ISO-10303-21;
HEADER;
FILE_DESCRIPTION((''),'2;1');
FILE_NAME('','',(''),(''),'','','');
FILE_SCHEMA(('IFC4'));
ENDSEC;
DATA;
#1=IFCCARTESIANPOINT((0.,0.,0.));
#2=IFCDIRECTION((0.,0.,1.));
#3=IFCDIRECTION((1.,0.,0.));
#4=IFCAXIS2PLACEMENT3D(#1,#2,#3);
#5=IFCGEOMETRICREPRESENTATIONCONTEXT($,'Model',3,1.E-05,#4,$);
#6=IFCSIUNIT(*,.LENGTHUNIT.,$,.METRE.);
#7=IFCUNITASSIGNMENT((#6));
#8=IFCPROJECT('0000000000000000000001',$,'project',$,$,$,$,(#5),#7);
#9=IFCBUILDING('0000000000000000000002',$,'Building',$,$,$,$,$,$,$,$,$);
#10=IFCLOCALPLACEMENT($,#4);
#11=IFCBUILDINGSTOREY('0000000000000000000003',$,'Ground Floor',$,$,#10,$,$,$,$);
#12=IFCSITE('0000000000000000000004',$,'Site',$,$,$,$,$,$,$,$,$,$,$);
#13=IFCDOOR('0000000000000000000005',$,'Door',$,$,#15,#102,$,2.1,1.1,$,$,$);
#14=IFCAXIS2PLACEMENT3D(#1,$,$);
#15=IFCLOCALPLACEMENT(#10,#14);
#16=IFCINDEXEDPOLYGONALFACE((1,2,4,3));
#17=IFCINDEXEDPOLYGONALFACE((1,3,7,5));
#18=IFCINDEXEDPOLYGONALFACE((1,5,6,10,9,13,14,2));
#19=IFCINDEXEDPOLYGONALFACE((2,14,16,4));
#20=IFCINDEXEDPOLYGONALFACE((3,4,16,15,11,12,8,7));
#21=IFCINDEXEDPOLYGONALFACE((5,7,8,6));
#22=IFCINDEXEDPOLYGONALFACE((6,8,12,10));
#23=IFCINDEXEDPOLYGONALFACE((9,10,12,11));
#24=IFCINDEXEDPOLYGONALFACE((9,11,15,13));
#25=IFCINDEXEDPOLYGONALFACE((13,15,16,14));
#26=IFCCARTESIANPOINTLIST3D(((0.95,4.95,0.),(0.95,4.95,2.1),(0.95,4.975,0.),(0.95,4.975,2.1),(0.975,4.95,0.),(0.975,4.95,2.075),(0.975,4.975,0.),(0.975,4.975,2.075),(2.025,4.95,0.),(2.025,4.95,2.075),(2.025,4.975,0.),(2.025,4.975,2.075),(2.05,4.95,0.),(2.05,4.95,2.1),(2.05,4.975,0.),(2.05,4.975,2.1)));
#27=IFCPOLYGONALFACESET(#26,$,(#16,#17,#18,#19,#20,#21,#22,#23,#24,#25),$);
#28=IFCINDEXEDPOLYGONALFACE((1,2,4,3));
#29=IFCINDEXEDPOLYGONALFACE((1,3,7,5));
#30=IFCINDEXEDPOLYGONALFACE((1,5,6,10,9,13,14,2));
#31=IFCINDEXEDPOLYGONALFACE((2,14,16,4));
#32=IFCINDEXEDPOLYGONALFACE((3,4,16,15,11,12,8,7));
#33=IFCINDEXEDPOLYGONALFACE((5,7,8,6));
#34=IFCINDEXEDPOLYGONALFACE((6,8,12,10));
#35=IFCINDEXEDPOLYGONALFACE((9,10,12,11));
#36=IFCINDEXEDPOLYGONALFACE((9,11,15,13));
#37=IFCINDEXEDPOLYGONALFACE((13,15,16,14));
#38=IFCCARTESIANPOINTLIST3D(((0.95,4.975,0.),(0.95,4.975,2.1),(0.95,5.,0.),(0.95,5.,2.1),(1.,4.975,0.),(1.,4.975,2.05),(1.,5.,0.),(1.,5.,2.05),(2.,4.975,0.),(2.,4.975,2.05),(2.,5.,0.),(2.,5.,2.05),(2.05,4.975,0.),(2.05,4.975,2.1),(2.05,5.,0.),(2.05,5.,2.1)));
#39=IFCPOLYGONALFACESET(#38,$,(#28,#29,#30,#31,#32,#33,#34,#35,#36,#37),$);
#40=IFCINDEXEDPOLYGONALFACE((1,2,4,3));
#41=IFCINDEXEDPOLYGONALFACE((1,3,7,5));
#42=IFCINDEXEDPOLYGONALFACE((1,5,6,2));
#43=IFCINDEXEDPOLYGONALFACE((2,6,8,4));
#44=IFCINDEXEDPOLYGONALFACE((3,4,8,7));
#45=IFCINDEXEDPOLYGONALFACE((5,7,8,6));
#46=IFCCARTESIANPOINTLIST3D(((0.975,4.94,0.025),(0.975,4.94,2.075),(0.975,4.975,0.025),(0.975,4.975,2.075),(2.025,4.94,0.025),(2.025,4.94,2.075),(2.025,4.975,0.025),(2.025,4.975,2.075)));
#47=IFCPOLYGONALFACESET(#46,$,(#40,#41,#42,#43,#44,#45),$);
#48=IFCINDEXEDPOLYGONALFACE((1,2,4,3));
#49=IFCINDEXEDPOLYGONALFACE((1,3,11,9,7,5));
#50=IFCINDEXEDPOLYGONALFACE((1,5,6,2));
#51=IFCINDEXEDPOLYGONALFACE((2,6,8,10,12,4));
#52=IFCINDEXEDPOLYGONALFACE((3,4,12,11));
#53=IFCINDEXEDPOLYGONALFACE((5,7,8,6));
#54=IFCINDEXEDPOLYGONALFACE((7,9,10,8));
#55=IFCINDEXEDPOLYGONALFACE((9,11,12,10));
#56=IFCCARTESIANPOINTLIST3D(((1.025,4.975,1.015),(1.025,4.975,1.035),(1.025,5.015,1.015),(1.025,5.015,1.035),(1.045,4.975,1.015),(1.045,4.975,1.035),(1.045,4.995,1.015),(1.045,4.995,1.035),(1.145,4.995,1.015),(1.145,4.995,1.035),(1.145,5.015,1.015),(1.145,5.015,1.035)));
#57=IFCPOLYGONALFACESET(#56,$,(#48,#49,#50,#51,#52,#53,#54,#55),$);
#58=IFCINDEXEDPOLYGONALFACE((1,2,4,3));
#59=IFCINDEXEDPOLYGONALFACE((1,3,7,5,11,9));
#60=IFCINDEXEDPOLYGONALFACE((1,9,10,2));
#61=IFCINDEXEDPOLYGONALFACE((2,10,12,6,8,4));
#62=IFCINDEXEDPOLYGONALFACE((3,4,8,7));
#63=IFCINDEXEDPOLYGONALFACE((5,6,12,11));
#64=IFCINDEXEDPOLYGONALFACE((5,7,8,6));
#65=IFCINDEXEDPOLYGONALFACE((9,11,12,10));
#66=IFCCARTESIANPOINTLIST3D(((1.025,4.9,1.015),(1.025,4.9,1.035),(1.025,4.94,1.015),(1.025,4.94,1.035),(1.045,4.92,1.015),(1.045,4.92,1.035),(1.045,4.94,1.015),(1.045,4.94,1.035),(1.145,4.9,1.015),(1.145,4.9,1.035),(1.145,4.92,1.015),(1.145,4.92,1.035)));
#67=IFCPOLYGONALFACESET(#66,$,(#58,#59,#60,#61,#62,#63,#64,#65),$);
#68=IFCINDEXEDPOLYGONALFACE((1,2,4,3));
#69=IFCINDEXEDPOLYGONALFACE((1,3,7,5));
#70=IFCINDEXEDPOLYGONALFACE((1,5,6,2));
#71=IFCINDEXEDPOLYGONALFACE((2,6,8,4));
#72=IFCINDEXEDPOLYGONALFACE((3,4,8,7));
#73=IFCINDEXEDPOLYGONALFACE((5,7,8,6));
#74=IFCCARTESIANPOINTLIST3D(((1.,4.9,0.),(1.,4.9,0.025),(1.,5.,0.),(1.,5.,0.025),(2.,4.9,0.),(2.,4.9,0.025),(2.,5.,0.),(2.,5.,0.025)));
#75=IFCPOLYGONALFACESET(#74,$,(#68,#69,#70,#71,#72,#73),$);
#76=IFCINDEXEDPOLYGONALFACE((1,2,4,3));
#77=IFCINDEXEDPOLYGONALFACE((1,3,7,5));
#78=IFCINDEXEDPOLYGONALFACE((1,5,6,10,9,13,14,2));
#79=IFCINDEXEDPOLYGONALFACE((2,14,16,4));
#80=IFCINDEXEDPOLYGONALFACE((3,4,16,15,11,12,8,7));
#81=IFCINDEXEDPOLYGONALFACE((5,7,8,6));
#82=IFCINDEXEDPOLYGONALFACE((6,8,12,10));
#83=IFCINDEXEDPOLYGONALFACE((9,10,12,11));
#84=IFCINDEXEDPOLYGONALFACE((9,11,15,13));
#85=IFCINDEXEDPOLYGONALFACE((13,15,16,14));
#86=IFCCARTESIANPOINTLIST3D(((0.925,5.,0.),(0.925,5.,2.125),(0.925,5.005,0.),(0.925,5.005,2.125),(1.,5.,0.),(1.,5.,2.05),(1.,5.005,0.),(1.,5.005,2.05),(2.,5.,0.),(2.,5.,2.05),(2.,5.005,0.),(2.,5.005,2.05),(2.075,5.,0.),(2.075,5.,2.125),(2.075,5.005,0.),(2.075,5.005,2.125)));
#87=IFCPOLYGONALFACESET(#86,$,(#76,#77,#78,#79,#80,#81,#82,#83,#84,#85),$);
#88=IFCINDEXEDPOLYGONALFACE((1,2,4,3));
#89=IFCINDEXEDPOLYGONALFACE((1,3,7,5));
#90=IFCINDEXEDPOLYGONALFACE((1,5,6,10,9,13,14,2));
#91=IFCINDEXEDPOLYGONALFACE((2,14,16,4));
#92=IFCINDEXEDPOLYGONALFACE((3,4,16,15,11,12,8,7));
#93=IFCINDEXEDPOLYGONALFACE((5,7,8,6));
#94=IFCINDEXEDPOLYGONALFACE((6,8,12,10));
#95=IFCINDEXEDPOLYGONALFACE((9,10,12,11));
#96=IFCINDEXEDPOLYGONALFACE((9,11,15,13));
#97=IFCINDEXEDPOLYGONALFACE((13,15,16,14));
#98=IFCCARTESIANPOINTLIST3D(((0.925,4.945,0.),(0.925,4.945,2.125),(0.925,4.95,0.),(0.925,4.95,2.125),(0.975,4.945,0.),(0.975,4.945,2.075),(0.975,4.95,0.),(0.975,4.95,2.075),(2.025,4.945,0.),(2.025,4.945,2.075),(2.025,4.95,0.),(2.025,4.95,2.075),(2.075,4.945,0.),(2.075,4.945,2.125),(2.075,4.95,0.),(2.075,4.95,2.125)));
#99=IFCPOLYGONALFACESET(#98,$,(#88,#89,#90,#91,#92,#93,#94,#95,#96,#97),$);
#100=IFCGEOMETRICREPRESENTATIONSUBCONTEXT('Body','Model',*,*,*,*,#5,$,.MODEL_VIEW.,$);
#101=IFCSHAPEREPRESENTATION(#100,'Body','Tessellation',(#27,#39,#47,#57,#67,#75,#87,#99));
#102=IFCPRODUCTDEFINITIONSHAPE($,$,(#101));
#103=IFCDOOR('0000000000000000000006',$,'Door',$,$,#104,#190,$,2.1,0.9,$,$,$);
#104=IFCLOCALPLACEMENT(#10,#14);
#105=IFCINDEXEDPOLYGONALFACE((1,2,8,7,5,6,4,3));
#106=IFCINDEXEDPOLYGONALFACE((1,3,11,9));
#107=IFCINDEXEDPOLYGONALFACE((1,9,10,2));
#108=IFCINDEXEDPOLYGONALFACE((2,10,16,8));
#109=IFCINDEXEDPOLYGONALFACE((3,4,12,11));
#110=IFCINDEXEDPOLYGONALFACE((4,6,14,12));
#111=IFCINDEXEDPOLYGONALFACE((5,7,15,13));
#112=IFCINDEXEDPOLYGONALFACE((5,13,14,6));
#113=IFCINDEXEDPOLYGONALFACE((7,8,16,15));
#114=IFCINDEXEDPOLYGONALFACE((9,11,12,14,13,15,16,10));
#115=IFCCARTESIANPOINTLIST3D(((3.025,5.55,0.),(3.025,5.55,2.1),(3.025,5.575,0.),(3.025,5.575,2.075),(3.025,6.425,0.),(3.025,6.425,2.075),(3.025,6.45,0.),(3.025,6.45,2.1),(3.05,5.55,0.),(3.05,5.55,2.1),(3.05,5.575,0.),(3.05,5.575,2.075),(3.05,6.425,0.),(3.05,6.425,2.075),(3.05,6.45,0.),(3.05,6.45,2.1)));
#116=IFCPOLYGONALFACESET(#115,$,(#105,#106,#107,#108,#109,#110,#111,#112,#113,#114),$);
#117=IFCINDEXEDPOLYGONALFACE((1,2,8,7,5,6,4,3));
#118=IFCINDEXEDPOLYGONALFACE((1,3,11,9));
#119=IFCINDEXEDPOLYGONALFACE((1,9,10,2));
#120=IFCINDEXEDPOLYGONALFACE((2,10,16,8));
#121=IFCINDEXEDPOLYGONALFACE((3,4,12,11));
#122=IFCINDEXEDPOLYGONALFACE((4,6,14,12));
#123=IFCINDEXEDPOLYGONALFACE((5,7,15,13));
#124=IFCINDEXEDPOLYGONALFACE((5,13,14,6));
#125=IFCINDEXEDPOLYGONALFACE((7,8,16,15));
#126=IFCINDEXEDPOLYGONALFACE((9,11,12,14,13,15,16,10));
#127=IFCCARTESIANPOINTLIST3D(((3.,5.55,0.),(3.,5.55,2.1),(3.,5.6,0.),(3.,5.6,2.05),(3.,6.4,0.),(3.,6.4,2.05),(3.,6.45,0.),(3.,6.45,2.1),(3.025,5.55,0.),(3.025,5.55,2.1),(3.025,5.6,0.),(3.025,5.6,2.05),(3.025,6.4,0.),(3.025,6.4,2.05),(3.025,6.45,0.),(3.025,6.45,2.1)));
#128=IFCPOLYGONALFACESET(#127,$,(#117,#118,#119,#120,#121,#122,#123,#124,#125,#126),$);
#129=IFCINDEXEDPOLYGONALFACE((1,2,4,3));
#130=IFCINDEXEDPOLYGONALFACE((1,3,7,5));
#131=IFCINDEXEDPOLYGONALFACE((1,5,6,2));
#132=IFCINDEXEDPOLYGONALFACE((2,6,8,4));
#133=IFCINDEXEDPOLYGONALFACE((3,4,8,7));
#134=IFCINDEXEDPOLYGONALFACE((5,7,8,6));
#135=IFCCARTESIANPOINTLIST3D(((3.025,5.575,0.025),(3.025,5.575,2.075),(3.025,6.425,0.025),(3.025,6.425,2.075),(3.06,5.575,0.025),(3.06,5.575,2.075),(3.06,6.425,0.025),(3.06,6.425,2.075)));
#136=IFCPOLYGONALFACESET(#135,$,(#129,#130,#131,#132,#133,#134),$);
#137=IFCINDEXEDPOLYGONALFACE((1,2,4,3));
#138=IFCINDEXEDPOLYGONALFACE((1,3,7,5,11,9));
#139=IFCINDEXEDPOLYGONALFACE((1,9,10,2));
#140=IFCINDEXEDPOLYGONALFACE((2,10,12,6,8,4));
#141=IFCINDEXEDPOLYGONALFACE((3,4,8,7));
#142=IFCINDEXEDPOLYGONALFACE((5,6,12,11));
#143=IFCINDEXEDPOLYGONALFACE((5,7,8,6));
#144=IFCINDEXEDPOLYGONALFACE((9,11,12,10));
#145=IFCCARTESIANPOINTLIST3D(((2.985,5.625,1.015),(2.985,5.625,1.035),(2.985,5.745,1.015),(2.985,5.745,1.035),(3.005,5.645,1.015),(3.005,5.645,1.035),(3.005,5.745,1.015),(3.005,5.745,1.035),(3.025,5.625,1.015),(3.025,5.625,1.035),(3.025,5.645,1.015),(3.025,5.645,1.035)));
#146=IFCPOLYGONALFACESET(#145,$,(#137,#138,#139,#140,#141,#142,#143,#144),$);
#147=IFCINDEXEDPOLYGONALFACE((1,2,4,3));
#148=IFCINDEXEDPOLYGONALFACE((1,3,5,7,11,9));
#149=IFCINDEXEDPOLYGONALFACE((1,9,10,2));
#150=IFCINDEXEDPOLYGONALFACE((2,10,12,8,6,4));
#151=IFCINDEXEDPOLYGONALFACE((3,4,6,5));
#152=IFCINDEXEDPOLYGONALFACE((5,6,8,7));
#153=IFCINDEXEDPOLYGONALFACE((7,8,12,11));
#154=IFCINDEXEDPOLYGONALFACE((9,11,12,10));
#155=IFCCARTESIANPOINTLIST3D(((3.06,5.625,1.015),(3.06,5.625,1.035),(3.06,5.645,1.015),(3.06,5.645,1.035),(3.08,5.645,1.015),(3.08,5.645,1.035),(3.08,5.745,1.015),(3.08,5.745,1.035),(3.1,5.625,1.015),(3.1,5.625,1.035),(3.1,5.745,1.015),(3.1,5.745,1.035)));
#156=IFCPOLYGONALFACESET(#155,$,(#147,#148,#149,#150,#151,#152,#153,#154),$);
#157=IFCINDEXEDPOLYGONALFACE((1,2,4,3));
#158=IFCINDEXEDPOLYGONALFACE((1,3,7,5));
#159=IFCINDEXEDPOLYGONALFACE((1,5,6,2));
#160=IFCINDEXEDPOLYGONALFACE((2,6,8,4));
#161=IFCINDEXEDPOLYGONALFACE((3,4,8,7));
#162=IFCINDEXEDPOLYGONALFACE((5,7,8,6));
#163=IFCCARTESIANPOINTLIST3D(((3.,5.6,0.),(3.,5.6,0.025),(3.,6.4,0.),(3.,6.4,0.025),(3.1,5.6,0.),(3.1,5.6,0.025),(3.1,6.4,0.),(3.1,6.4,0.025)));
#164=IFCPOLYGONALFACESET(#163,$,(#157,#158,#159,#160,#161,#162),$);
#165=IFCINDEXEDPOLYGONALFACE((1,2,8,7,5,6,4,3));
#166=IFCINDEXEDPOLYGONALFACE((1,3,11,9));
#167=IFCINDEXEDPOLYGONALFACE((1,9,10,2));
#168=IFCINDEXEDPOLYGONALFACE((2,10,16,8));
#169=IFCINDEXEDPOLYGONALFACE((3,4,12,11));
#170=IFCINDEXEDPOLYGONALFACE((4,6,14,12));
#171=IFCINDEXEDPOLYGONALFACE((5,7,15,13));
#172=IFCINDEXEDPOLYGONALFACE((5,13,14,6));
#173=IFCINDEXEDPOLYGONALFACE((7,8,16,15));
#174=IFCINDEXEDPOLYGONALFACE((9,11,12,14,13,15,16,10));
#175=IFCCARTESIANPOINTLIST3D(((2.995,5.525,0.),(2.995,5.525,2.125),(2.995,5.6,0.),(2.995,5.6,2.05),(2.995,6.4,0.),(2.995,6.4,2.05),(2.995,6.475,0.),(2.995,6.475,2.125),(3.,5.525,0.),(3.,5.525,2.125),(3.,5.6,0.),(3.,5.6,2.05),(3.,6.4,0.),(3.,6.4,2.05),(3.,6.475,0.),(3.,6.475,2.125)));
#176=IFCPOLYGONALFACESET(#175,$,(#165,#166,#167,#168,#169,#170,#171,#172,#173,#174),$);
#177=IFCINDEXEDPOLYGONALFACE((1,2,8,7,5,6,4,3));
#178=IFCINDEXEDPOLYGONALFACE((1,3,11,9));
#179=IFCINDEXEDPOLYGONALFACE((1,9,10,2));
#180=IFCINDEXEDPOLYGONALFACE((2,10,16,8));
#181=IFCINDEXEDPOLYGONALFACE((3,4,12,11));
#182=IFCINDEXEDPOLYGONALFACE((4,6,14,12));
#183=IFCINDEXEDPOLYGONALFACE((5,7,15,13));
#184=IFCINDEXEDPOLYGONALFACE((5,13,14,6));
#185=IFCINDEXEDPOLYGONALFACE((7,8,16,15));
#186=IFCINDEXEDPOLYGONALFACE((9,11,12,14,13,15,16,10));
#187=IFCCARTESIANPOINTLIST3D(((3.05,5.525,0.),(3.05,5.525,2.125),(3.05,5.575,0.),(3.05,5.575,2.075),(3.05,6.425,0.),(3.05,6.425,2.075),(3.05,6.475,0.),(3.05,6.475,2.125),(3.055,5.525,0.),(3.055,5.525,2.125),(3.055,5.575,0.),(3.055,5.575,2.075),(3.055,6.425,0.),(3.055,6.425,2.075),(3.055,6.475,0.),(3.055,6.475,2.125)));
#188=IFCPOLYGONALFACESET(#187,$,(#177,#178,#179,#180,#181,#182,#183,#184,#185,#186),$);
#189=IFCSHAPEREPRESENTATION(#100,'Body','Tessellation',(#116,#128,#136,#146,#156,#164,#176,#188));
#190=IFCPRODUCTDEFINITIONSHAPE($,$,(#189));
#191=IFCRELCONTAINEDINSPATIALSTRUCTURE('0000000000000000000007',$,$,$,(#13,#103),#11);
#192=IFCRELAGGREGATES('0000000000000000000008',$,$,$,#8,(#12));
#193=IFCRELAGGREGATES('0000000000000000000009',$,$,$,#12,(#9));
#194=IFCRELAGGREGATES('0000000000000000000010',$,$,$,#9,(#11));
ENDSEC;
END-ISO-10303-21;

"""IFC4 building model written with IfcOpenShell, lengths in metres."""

from ifc_helpers import new_model, si_unit, frame, origin_with_axes, place, context, subcontext, project, spatial, line, indexed_curve, outline, extrude, element, save


model = new_model("IFC4")

# Units and contexts
model_context = context("Model", 3, precision=1e-05, world=origin_with_axes())
body_context = subcontext(model_context, "Body", "Model", "MODEL_VIEW")
ifc_project = project(units=[si_unit("LENGTHUNIT", "METRE")], contexts=[model_context])

# Site, building, storey
site = spatial("IfcSite", under=ifc_project, Name="Site")
building = spatial("IfcBuilding", under=site, Name="Building")
storey_placement = place(None, origin_with_axes())
storey = spatial("IfcBuildingStorey", under=building, at=storey_placement, Name="Ground Floor")

# Doors
door_1_placement = place(storey_placement, frame((2.05, 5.0, 0.0), z_axis=(0.0, 0.0, 1.0), x_axis=(-1.0, 0.0, 0.0)))
element("IfcDoor", 1, at=door_1_placement, inside=storey, Name="Door", OverallHeight=2.1, OverallWidth=1.1, context=body_context, shape_type="SweptSolid", body=[
    extrude(outline(indexed_curve([(0.0, 0.0), (0.0, 2.1), (1.1, 2.1), (1.1, 0.0), (1.075, 0.0), (1.075, 2.075), (0.025, 2.075), (0.025, 0.0)], segments=[line(1, 2, 3, 4, 5, 6, 7, 8, 1)])), frame((0.0, 0.025, 0.0), z_axis=(0.0, -1.0, 0.0), x_axis=(1.0, 0.0, 0.0)), (0.0, 0.0, -1.0), 0.025),
    extrude(outline(indexed_curve([(0.0, 0.0), (0.0, 2.1), (1.1, 2.1), (1.1, 0.0), (1.05, 0.0), (1.05, 2.05), (0.05, 2.05), (0.05, 0.0)], segments=[line(1, 2, 3, 4, 5, 6, 7, 8, 1)])), frame((0.0, 0.0, 0.0), z_axis=(0.0, -1.0, 0.0), x_axis=(1.0, 0.0, 0.0)), (0.0, 0.0, -1.0), 0.025),
    extrude(outline(indexed_curve([(0.0, 0.0), (1.05, 0.0), (1.05, 0.035), (0.0, 0.035)], segments=[line(1, 2, 3, 4, 1)])), frame((0.025, 0.025, 0.025), z_axis=(0.0, 0.0, 1.0), x_axis=(1.0, 0.0, 0.0)), (0.0, 0.0, 1.0), 2.05),
    extrude(outline(indexed_curve([(0.0, 0.0), (0.0, -0.04), (-0.12, -0.04), (-0.12, -0.02), (-0.02, -0.02), (-0.02, 0.0)], segments=[line(1, 2, 3, 4, 5, 6, 1)])), frame((1.025, 0.025, 1.015), z_axis=(0.0, 0.0, 1.0), x_axis=(1.0, 0.0, 0.0)), (0.0, 0.0, 1.0), 0.02),
    extrude(outline(indexed_curve([(0.0, 0.0), (0.0, 0.04), (-0.12, 0.04), (-0.12, 0.02), (-0.02, 0.02), (-0.02, 0.0)], segments=[line(1, 2, 3, 4, 5, 6, 1)])), frame((1.025, 0.06, 1.015), z_axis=(0.0, 0.0, 1.0), x_axis=(1.0, 0.0, 0.0)), (0.0, 0.0, 1.0), 0.02),
    extrude(outline(indexed_curve([(0.0, 0.0), (1.0, 0.0), (1.0, 0.1), (0.0, 0.1)], segments=[line(1, 2, 3, 4, 1)])), frame((0.05, 0.0, 0.0), z_axis=(0.0, 0.0, 1.0), x_axis=(1.0, 0.0, 0.0)), (0.0, 0.0, 1.0), 0.025),
    extrude(outline(indexed_curve([(0.0, 0.0), (0.0, 2.125), (1.15, 2.125), (1.15, 0.0), (1.075, 0.0), (1.075, 2.05), (0.075, 2.05), (0.075, 0.0)], segments=[line(1, 2, 3, 4, 5, 6, 7, 8, 1)])), frame((-0.025, -0.005, 0.0), z_axis=(0.0, -1.0, 0.0), x_axis=(1.0, 0.0, 0.0)), (0.0, 0.0, -1.0), 0.005),
    extrude(outline(indexed_curve([(0.0, 0.0), (0.0, 2.125), (1.15, 2.125), (1.15, 0.0), (1.1, 0.0), (1.1, 2.075), (0.05, 2.075), (0.05, 0.0)], segments=[line(1, 2, 3, 4, 5, 6, 7, 8, 1)])), frame((-0.025, 0.05, 0.0), z_axis=(0.0, -1.0, 0.0), x_axis=(1.0, 0.0, 0.0)), (0.0, 0.0, -1.0), 0.005),
])
door_2_placement = place(storey_placement, frame((3.0, 6.45, 0.0), z_axis=(0.0, 0.0, 1.0), x_axis=(0.0, -1.0, 0.0)))
element("IfcDoor", 2, at=door_2_placement, inside=storey, Name="Door", OverallHeight=2.1, OverallWidth=0.9, context=body_context, shape_type="SweptSolid", body=[
    extrude(outline(indexed_curve([(0.0, 0.0), (0.0, 2.1), (0.9, 2.1), (0.9, 0.0), (0.875, 0.0), (0.875, 2.075), (0.025, 2.075), (0.025, 0.0)], segments=[line(1, 2, 3, 4, 5, 6, 7, 8, 1)])), frame((0.0, 0.025, 0.0), z_axis=(0.0, -1.0, 0.0), x_axis=(1.0, 0.0, 0.0)), (0.0, 0.0, -1.0), 0.025),
    extrude(outline(indexed_curve([(0.0, 0.0), (0.0, 2.1), (0.9, 2.1), (0.9, 0.0), (0.85, 0.0), (0.85, 2.05), (0.05, 2.05), (0.05, 0.0)], segments=[line(1, 2, 3, 4, 5, 6, 7, 8, 1)])), frame((0.0, 0.0, 0.0), z_axis=(0.0, -1.0, 0.0), x_axis=(1.0, 0.0, 0.0)), (0.0, 0.0, -1.0), 0.025),
    extrude(outline(indexed_curve([(0.0, 0.0), (0.85, 0.0), (0.85, 0.035), (0.0, 0.035)], segments=[line(1, 2, 3, 4, 1)])), frame((0.025, 0.025, 0.025), z_axis=(0.0, 0.0, 1.0), x_axis=(1.0, 0.0, 0.0)), (0.0, 0.0, 1.0), 2.05),
    extrude(outline(indexed_curve([(0.0, 0.0), (0.0, -0.04), (-0.12, -0.04), (-0.12, -0.02), (-0.02, -0.02), (-0.02, 0.0)], segments=[line(1, 2, 3, 4, 5, 6, 1)])), frame((0.825, 0.025, 1.015), z_axis=(0.0, 0.0, 1.0), x_axis=(1.0, 0.0, 0.0)), (0.0, 0.0, 1.0), 0.02),
    extrude(outline(indexed_curve([(0.0, 0.0), (0.0, 0.04), (-0.12, 0.04), (-0.12, 0.02), (-0.02, 0.02), (-0.02, 0.0)], segments=[line(1, 2, 3, 4, 5, 6, 1)])), frame((0.825, 0.06, 1.015), z_axis=(0.0, 0.0, 1.0), x_axis=(1.0, 0.0, 0.0)), (0.0, 0.0, 1.0), 0.02),
    extrude(outline(indexed_curve([(0.0, 0.0), (0.8, 0.0), (0.8, 0.1), (0.0, 0.1)], segments=[line(1, 2, 3, 4, 1)])), frame((0.05, 0.0, 0.0), z_axis=(0.0, 0.0, 1.0), x_axis=(1.0, 0.0, 0.0)), (0.0, 0.0, 1.0), 0.025),
    extrude(outline(indexed_curve([(0.0, 0.0), (0.0, 2.125), (0.95, 2.125), (0.95, 0.0), (0.875, 0.0), (0.875, 2.05), (0.075, 2.05), (0.075, 0.0)], segments=[line(1, 2, 3, 4, 5, 6, 7, 8, 1)])), frame((-0.025, -0.005, 0.0), z_axis=(0.0, -1.0, 0.0), x_axis=(1.0, 0.0, 0.0)), (0.0, 0.0, -1.0), 0.005),
    extrude(outline(indexed_curve([(0.0, 0.0), (0.0, 2.125), (0.95, 2.125), (0.95, 0.0), (0.9, 0.0), (0.9, 2.075), (0.05, 2.075), (0.05, 0.0)], segments=[line(1, 2, 3, 4, 5, 6, 7, 8, 1)])), frame((-0.025, 0.05, 0.0), z_axis=(0.0, -1.0, 0.0), x_axis=(1.0, 0.0, 0.0)), (0.0, 0.0, -1.0), 0.005),
])

save(model, "model.ifc")
